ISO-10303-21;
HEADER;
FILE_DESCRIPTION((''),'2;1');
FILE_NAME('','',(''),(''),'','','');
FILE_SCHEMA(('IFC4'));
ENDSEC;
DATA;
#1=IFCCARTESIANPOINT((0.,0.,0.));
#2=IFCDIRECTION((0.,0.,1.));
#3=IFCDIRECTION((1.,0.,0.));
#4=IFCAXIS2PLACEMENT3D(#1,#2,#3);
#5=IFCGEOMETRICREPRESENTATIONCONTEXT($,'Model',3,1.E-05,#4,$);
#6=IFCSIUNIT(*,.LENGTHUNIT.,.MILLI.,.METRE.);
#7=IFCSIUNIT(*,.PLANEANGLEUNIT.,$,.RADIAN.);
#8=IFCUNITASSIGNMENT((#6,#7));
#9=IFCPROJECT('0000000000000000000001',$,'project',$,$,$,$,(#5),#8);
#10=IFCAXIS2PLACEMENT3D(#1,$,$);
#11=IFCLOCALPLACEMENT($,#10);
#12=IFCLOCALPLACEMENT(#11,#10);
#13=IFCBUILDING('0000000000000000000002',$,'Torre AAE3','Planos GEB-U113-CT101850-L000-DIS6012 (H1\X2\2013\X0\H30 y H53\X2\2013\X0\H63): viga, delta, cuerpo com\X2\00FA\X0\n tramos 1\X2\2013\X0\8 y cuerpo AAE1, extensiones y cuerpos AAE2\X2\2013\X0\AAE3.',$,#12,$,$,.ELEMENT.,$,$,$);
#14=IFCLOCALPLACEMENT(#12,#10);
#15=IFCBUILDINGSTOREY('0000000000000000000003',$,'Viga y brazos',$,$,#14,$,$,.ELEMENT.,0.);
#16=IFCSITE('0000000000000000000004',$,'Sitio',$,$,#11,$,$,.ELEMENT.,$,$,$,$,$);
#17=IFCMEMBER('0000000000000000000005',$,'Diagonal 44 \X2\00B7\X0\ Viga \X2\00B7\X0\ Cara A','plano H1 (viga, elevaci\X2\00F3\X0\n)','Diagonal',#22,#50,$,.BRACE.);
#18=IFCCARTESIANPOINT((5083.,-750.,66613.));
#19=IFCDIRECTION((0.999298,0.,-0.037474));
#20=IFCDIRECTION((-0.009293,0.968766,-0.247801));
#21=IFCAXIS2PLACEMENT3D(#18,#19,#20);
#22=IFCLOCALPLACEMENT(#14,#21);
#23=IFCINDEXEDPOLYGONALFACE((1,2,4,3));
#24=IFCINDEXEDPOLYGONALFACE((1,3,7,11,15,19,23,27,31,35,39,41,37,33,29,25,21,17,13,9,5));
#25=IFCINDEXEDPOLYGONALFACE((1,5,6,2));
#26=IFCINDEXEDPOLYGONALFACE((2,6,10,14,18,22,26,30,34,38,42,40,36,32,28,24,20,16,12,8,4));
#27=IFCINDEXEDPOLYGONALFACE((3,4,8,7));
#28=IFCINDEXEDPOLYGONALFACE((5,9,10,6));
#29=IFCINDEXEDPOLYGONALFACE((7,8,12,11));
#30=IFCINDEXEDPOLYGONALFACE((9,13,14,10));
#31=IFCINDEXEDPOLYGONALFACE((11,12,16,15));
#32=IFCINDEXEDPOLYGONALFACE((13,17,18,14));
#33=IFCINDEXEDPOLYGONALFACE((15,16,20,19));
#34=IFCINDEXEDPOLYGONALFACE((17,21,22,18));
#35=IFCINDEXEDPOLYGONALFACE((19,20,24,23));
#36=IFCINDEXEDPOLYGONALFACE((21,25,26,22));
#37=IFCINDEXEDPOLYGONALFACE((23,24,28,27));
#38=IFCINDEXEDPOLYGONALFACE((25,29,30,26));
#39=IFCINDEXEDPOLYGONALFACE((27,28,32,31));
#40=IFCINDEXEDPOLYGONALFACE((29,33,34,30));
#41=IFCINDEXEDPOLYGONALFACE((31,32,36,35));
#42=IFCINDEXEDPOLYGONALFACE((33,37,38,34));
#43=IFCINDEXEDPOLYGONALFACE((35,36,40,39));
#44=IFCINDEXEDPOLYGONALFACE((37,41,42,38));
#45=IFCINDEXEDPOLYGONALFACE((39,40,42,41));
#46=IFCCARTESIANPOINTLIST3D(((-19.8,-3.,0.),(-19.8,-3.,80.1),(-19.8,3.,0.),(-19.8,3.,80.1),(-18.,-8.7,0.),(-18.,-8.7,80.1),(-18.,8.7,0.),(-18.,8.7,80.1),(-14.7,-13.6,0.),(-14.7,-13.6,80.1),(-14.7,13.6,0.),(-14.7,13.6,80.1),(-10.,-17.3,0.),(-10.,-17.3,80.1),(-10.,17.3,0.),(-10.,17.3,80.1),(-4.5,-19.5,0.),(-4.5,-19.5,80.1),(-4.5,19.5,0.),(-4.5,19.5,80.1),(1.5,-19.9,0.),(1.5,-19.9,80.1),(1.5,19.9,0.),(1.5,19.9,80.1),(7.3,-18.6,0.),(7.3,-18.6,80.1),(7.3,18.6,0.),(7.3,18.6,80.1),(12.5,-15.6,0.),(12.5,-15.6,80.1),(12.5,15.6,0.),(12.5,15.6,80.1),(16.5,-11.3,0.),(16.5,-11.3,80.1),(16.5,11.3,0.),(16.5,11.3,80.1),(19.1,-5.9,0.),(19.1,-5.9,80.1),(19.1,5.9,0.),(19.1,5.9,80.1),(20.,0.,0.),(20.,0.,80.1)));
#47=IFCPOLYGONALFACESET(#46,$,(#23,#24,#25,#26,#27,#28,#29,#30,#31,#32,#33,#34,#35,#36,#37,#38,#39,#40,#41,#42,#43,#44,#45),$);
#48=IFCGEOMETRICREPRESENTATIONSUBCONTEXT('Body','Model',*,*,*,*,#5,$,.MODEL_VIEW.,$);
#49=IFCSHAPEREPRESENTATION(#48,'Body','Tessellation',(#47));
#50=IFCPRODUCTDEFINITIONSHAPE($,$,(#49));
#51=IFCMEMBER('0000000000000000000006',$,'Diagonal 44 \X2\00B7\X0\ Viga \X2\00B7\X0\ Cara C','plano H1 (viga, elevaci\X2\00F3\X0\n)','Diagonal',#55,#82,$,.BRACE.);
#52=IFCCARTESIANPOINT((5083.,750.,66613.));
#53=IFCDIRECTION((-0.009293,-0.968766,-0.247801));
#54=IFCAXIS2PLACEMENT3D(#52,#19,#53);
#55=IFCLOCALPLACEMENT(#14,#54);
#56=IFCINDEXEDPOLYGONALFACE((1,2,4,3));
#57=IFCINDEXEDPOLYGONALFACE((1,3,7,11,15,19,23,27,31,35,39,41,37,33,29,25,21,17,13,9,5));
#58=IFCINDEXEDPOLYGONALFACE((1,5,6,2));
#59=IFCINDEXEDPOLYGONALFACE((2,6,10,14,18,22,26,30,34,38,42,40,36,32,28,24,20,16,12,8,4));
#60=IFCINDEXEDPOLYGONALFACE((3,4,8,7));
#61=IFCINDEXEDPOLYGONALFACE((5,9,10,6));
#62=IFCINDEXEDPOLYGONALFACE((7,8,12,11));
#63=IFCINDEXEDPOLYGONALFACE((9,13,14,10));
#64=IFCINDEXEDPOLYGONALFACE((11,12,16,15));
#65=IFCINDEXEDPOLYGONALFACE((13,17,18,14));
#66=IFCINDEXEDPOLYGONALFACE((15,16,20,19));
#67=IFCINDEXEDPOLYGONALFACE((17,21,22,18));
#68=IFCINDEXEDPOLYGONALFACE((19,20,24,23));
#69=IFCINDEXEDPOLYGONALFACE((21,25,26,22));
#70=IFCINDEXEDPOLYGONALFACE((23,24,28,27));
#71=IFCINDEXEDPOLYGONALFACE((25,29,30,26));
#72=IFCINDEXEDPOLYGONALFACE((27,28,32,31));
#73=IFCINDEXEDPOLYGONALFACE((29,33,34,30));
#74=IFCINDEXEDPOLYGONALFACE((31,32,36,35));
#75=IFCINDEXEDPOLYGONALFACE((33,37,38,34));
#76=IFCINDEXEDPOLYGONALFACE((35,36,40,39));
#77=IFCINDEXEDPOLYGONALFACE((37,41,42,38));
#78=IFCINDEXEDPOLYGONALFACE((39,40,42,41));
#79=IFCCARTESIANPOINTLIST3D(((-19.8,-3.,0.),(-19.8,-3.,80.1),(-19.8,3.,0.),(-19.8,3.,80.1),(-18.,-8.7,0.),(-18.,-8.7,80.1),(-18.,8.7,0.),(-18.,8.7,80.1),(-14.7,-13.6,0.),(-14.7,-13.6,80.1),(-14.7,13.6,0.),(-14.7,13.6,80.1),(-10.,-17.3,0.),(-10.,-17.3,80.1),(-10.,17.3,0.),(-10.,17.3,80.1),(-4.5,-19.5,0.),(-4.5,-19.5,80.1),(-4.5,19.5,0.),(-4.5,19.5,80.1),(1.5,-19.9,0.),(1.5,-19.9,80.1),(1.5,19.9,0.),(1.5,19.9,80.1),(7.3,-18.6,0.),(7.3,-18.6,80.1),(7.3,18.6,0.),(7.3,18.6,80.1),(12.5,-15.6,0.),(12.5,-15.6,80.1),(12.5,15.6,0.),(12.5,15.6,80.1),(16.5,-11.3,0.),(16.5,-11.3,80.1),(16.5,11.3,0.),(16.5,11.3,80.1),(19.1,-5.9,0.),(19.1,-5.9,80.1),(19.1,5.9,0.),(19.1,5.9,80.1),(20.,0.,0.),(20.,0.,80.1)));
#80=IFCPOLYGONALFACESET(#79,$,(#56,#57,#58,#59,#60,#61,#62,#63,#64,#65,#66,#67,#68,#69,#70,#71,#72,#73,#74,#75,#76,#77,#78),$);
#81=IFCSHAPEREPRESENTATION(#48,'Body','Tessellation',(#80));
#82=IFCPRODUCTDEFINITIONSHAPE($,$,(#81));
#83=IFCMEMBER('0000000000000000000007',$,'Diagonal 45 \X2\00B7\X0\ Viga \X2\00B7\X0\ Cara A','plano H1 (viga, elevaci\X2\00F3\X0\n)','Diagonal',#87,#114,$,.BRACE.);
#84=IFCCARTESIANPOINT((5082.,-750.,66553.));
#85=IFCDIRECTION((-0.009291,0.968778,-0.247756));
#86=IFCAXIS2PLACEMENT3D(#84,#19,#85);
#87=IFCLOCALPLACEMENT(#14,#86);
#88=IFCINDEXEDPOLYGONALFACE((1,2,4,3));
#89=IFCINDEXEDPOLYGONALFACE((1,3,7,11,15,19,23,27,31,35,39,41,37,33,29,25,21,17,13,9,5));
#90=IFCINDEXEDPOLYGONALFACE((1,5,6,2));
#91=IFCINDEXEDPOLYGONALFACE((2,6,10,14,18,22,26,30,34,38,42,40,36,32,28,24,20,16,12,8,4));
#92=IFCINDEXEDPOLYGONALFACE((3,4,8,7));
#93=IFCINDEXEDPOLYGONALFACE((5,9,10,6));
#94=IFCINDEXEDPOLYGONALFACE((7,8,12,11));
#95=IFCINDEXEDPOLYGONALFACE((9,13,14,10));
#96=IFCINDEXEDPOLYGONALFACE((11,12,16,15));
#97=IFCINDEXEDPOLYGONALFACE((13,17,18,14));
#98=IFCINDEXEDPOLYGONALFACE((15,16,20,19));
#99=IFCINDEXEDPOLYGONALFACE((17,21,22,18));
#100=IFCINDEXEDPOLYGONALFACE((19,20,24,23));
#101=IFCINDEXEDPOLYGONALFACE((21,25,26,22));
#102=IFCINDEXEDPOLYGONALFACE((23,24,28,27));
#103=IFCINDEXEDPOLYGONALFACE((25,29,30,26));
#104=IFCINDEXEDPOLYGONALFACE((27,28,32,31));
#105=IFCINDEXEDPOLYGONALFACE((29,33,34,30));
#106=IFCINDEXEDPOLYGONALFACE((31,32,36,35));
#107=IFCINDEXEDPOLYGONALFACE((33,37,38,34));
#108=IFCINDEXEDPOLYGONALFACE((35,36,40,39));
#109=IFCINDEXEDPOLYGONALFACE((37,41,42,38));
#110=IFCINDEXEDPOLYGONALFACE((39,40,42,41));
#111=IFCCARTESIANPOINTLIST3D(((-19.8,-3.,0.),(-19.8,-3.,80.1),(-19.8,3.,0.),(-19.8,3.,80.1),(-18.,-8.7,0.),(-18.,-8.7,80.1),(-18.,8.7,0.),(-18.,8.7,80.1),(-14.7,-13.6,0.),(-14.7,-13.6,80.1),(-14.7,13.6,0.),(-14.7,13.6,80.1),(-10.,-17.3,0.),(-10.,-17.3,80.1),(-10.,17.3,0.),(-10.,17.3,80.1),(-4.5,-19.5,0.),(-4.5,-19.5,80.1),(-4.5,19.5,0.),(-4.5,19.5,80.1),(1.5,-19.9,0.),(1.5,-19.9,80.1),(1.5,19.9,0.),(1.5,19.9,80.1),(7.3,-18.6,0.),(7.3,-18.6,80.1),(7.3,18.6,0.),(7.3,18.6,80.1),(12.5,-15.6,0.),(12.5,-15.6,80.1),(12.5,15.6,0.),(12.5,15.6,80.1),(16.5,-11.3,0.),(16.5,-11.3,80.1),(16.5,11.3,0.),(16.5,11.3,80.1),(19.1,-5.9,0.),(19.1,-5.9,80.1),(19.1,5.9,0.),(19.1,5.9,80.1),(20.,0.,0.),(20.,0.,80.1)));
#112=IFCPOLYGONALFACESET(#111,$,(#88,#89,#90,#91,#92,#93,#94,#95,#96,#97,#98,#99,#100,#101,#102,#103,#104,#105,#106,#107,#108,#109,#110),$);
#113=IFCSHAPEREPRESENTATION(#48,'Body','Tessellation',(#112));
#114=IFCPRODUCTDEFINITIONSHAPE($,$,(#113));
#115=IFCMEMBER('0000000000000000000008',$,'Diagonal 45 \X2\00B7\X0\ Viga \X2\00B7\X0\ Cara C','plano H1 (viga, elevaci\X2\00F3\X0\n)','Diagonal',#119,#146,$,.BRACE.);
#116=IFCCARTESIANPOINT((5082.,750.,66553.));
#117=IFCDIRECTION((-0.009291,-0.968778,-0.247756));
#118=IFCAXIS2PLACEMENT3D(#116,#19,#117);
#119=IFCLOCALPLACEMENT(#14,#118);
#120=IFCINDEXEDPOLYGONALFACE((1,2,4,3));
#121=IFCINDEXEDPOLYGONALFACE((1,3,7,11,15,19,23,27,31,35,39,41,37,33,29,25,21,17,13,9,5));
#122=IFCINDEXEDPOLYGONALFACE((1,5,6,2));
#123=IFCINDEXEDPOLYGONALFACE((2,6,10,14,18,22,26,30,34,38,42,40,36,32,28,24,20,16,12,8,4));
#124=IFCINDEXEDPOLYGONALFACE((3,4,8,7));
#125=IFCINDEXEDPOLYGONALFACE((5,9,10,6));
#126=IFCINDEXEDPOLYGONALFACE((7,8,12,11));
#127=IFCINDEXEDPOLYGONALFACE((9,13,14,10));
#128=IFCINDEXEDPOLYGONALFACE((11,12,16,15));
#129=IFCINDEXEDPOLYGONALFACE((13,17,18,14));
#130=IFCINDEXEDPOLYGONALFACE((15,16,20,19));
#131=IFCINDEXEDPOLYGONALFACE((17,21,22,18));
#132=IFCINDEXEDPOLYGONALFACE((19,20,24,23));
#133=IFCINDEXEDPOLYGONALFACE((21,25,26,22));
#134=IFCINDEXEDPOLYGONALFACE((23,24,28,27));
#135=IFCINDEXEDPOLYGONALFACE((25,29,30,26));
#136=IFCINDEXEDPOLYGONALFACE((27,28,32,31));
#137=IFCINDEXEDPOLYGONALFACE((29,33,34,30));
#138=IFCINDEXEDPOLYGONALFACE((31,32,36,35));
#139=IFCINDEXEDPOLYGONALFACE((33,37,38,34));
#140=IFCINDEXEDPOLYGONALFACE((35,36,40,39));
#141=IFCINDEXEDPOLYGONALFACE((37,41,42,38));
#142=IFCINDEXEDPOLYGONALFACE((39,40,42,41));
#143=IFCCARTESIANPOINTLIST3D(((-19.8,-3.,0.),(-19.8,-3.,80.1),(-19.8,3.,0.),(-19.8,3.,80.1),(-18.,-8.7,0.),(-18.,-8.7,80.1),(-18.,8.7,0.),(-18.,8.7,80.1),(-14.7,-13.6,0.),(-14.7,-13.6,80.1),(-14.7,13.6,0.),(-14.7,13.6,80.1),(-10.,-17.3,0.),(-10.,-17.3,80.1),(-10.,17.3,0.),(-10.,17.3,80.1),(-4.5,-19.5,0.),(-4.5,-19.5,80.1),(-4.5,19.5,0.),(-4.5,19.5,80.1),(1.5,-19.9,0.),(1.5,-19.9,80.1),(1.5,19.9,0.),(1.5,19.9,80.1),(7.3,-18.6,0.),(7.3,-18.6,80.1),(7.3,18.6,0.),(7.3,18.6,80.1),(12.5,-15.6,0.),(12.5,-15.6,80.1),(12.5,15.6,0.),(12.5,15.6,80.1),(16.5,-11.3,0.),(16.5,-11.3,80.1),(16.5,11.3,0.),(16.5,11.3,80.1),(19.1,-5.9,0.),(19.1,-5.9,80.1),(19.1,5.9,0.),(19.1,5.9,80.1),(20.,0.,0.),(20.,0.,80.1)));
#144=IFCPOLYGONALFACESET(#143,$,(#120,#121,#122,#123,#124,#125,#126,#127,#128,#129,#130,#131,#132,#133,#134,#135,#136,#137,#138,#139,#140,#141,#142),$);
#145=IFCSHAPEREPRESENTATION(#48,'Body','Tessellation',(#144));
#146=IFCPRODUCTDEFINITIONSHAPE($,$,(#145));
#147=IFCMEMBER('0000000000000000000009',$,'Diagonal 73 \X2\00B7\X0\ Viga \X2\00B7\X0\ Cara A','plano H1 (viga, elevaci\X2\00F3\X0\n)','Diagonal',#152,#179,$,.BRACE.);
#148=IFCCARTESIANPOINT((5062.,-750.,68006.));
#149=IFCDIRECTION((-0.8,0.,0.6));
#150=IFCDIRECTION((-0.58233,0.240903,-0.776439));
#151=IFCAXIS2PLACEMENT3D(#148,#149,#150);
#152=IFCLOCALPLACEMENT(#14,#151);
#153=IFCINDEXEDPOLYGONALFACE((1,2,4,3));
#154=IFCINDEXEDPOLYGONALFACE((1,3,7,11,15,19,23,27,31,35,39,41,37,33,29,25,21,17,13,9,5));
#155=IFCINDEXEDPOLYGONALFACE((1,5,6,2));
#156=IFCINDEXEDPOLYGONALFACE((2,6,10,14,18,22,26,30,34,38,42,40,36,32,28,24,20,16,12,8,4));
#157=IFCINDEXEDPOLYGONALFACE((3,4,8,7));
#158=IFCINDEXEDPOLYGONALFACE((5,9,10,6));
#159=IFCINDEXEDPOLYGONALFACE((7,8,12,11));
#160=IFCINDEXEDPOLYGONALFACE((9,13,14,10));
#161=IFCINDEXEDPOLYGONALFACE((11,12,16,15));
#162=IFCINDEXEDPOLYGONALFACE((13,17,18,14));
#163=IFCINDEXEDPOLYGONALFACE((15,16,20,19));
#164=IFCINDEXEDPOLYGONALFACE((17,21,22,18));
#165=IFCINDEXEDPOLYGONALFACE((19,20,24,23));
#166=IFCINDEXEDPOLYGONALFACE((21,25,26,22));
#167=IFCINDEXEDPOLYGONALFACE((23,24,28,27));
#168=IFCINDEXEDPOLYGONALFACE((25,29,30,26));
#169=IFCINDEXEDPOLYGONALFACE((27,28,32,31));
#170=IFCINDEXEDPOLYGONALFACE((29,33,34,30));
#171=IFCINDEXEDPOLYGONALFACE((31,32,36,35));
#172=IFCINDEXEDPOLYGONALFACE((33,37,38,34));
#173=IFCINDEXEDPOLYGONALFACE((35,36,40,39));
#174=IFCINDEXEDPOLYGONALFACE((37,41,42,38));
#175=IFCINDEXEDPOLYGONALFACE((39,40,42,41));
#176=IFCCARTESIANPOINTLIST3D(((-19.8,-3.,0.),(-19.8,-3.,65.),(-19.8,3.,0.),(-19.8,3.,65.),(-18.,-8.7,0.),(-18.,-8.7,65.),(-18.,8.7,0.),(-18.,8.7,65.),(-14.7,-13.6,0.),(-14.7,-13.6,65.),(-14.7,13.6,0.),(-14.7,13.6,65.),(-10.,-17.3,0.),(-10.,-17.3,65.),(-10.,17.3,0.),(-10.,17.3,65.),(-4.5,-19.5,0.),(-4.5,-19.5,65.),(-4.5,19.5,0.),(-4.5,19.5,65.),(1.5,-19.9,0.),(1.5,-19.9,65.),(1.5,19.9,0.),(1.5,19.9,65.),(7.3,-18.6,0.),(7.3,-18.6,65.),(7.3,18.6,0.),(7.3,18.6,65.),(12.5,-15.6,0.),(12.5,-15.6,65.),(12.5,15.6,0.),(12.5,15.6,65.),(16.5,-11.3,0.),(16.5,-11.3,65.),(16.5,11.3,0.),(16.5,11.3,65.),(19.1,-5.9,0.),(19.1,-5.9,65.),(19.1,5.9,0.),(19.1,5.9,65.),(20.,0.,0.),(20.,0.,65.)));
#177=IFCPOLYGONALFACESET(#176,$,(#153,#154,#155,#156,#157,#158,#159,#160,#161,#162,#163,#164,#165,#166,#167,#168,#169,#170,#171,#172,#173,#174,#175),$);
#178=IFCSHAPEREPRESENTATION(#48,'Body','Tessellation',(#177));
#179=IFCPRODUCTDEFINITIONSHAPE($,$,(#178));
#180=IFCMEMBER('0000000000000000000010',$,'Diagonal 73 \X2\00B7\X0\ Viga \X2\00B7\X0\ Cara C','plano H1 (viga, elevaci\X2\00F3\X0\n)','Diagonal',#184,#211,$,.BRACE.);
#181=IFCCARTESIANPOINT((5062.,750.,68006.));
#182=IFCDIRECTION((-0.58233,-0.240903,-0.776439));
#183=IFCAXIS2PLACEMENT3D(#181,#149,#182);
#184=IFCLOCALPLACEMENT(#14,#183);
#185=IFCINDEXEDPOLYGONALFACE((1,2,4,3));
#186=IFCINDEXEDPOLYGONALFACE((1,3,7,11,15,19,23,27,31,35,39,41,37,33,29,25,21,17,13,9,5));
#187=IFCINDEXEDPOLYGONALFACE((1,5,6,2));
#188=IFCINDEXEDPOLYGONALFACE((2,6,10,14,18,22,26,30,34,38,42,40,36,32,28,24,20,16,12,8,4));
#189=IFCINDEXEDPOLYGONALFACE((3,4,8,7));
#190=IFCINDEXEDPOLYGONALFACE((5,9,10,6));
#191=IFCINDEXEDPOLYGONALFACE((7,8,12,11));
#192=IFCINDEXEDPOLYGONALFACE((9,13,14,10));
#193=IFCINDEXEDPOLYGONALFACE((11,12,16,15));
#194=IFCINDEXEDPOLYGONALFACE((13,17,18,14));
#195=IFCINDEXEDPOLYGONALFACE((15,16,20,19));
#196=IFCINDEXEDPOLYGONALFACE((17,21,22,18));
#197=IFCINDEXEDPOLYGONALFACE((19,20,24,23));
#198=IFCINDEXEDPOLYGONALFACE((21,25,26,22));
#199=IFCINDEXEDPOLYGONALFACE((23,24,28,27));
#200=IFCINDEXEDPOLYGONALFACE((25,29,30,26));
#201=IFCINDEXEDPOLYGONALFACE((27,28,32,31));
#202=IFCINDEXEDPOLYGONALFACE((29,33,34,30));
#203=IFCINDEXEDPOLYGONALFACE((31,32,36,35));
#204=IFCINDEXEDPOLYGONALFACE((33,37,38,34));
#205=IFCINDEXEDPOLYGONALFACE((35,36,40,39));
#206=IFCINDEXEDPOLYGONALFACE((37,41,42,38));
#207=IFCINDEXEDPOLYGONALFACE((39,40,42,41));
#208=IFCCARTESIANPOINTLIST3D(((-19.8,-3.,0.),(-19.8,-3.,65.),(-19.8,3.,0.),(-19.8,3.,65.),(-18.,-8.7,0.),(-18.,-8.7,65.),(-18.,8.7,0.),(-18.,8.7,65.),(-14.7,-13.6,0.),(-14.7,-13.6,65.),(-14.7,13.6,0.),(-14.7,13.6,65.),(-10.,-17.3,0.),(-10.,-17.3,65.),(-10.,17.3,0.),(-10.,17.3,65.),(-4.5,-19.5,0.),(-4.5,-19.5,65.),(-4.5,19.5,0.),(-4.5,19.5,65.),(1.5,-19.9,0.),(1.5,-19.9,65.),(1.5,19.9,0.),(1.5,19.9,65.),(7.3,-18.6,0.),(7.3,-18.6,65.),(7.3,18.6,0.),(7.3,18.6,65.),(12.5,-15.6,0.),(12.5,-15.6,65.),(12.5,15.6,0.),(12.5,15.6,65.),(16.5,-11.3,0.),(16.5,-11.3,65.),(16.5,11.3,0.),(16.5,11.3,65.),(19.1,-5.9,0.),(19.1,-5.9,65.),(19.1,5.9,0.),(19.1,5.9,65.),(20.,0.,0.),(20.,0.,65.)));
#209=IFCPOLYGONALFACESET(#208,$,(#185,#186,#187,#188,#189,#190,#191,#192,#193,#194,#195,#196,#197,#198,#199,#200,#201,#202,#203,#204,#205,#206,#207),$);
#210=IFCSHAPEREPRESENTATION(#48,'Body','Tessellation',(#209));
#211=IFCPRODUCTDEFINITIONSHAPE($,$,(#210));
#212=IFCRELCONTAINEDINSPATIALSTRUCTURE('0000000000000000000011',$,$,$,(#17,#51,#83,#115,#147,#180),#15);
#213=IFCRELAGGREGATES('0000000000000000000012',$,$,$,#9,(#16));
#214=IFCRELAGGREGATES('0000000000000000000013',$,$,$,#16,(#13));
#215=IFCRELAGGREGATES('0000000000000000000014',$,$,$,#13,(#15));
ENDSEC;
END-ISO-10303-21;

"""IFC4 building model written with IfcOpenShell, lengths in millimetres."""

from ifc_helpers import new_model, si_unit, frame, origin, origin_with_axes, place, context, subcontext, project, spatial, circle, extrude, element, save


model = new_model("IFC4")

# Units and contexts
model_context = context("Model", 3, precision=1e-05, world=origin_with_axes())
body_context = subcontext(model_context, "Body", "Model", "MODEL_VIEW")
ifc_project = project(units=[si_unit("LENGTHUNIT", "METRE", prefix="MILLI"), si_unit("PLANEANGLEUNIT", "RADIAN")], contexts=[model_context])

# Site, building, storey
site_placement = place(None, origin())
site = spatial("IfcSite", under=ifc_project, at=site_placement, Name="Sitio", CompositionType="ELEMENT")
building_placement = place(site_placement, origin())
building = spatial("IfcBuilding", under=site, at=building_placement, Name="Torre AAE3", Description="Planos GEB-U113-CT101850-L000-DIS6012 (H1–H30 y H53–H63): viga, delta, cuerpo común tramos 1–8 y cuerpo AAE1, extensiones y cuerpos AAE2–AAE3.", CompositionType="ELEMENT")
storey_placement = place(building_placement, origin())
storey = spatial("IfcBuildingStorey", under=building, at=storey_placement, Name="Viga y brazos", CompositionType="ELEMENT", Elevation=0.0)

# Members
for number, where, z_axis, x_axis, name in (
    (1, (5083.0, -750.0, 66613.0), (0.999298, 0.0, -0.037474), (-0.009293, 0.968766, -0.247801), "Diagonal 44 · Viga · Cara A"),
    (2, (5083.0, 750.0, 66613.0), (0.999298, 0.0, -0.037474), (-0.009293, -0.968766, -0.247801), "Diagonal 44 · Viga · Cara C"),
    (3, (5082.0, -750.0, 66553.0), (0.999298, 0.0, -0.037474), (-0.009291, 0.968778, -0.247756), "Diagonal 45 · Viga · Cara A"),
    (4, (5082.0, 750.0, 66553.0), (0.999298, 0.0, -0.037474), (-0.009291, -0.968778, -0.247756), "Diagonal 45 · Viga · Cara C"),
):
    element("IfcMember", number, at=place(storey_placement, frame(where, z_axis=z_axis, x_axis=x_axis)), inside=storey, Name=name, Description="plano H1 (viga, elevación)", ObjectType="Diagonal", PredefinedType="BRACE", context=body_context, shape_type="SweptSolid", body=[
        extrude(circle(Radius=20.0), None, (0.0, 0.0, 1.0), 80.1),
    ])
for number, where, z_axis, x_axis, name in (
    (5, (5062.0, -750.0, 68006.0), (-0.8, 0.0, 0.6), (-0.58233, 0.240903, -0.776439), "Diagonal 73 · Viga · Cara A"),
    (6, (5062.0, 750.0, 68006.0), (-0.8, 0.0, 0.6), (-0.58233, -0.240903, -0.776439), "Diagonal 73 · Viga · Cara C"),
):
    element("IfcMember", number, at=place(storey_placement, frame(where, z_axis=z_axis, x_axis=x_axis)), inside=storey, Name=name, Description="plano H1 (viga, elevación)", ObjectType="Diagonal", PredefinedType="BRACE", context=body_context, shape_type="SweptSolid", body=[
        extrude(circle(Radius=20.0), None, (0.0, 0.0, 1.0), 65.0),
    ])

save(model, "model.ifc")
